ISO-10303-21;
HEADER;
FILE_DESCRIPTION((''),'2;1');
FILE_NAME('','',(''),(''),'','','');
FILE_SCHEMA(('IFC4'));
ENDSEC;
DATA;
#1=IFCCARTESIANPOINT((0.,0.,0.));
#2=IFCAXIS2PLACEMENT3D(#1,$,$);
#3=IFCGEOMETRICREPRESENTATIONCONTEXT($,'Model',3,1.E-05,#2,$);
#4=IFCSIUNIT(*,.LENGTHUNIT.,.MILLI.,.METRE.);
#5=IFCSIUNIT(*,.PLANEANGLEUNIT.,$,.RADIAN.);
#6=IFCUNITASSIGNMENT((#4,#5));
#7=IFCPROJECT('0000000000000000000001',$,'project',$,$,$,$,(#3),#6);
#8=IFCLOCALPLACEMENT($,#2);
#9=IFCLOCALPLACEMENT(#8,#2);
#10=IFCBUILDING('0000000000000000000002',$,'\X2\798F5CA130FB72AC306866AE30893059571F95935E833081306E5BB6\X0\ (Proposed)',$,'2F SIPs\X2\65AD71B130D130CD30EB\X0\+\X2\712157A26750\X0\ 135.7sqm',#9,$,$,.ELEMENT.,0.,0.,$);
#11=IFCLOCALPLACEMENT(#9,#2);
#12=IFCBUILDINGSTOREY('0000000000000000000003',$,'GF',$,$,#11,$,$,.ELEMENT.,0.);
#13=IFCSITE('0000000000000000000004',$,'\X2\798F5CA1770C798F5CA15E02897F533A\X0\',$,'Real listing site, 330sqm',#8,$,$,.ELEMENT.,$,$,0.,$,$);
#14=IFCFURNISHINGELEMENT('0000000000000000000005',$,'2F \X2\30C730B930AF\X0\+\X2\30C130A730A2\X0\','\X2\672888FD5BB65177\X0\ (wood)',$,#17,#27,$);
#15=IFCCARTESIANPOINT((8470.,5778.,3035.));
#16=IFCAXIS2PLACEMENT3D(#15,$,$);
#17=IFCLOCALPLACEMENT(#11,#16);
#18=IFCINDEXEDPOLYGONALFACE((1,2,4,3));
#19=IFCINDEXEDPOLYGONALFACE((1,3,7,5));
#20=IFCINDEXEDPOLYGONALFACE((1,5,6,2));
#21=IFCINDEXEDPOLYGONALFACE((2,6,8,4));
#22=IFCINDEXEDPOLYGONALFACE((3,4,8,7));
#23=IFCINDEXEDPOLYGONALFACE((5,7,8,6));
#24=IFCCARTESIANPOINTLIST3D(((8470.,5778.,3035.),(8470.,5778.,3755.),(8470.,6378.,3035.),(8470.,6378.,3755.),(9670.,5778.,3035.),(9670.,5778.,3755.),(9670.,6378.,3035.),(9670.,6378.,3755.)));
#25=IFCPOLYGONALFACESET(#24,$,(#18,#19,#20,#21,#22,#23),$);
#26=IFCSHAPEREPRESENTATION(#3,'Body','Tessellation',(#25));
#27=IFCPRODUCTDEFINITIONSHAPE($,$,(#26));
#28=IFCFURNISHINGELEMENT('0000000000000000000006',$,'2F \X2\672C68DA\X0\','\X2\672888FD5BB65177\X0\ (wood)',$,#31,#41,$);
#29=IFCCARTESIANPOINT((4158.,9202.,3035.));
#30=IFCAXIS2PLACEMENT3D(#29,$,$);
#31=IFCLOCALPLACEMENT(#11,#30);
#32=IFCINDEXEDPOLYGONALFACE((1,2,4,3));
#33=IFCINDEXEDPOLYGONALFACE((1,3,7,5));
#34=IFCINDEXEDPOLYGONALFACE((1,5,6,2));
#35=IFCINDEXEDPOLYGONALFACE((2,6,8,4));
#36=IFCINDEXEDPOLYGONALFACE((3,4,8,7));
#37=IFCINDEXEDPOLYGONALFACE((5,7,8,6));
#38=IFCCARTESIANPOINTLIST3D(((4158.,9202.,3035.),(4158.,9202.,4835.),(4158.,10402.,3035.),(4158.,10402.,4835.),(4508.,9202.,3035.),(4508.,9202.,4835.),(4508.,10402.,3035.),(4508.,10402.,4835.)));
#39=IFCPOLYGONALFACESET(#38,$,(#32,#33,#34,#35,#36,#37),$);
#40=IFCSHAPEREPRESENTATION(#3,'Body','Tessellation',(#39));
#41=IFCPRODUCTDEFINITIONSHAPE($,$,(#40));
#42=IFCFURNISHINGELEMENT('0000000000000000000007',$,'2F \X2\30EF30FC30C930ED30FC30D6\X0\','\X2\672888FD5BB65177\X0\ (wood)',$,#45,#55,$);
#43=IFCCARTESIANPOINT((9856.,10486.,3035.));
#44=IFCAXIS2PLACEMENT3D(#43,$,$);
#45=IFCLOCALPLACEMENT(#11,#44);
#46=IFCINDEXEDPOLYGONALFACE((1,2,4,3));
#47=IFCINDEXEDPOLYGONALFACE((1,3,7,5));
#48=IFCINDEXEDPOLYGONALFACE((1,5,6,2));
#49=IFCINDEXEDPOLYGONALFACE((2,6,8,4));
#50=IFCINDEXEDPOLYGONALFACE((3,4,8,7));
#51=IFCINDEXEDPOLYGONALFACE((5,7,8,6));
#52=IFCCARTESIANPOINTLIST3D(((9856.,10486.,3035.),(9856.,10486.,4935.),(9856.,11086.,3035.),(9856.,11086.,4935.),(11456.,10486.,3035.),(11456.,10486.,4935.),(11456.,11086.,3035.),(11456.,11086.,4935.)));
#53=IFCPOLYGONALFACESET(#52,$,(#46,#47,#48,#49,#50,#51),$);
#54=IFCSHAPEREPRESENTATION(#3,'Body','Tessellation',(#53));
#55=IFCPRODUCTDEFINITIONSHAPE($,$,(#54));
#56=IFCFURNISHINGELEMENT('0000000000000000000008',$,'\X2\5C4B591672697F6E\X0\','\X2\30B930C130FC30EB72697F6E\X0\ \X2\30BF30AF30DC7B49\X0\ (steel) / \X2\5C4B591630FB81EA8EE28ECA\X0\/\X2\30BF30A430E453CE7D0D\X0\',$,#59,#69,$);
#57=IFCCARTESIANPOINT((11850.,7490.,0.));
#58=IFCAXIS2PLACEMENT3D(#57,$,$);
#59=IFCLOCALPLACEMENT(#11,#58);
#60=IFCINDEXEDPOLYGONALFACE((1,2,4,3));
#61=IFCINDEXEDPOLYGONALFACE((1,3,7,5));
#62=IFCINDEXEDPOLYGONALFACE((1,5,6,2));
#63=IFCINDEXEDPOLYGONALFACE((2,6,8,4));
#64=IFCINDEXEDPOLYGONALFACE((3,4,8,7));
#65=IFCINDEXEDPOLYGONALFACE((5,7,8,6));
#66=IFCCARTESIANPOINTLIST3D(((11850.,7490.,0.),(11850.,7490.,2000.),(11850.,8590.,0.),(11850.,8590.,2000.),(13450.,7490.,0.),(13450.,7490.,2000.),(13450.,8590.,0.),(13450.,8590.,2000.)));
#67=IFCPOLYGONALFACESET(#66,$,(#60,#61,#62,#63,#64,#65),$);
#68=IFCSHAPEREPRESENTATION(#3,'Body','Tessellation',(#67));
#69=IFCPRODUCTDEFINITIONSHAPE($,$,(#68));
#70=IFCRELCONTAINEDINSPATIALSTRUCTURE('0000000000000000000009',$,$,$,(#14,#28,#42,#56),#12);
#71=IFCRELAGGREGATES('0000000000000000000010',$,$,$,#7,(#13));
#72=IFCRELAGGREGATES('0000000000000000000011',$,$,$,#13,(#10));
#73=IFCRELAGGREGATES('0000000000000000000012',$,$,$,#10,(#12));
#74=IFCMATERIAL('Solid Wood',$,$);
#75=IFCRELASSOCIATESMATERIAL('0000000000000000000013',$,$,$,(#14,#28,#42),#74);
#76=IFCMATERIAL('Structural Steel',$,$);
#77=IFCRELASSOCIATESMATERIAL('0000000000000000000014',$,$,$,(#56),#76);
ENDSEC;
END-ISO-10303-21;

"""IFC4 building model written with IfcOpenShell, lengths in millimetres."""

from ifc_helpers import new_model, si_unit, frame, frame_2d, origin, place, context, project, spatial, rectangle, extrude, material, element, save


model = new_model("IFC4")

# Units and contexts
model_context = context("Model", 3, precision=1e-05, world=origin())
ifc_project = project(units=[si_unit("LENGTHUNIT", "METRE", prefix="MILLI"), si_unit("PLANEANGLEUNIT", "RADIAN")], contexts=[model_context])

# Site, building, storey
site_placement = place(None, origin())
site = spatial("IfcSite", under=ifc_project, at=site_placement, Name="福岡県福岡市西区", ObjectType="Real listing site, 330sqm", CompositionType="ELEMENT", RefElevation=0.0)
building_placement = place(site_placement, origin())
building = spatial("IfcBuilding", under=site, at=building_placement, Name="福岡・犬と暮らす土間広めの家 (Proposed)", ObjectType="2F SIPs断熱パネル+無垢材 135.7sqm", CompositionType="ELEMENT", ElevationOfRefHeight=0.0, ElevationOfTerrain=0.0)
storey_placement = place(building_placement, origin())
storey = spatial("IfcBuildingStorey", under=building, at=storey_placement, Name="GF", CompositionType="ELEMENT", Elevation=0.0)

# Shared definitions
ifc_material_1 = material(Name="Solid Wood")

# Shared definitions
ifc_material_2 = material(Name="Structural Steel")

# Furnishing elements
furnishing_1_placement = place(storey_placement, frame((8470.0, 5778.0, 3035.0)))
element("IfcFurnishingElement", 1, at=furnishing_1_placement, inside=storey, material=ifc_material_1, Name="2F デスク+チェア", Description="木製家具 (wood)", context=model_context, shape_type="SweptSolid", body=[
    extrude(rectangle(XDim=1200.0, YDim=600.0, at=frame_2d((600.0, 300.0))), frame((8470.0, 5778.0, 3035.0)), (0.0, 0.0, 1.0), 720.0),
])
furnishing_2_placement = place(storey_placement, frame((4158.0, 9202.0, 3035.0)))
element("IfcFurnishingElement", 2, at=furnishing_2_placement, inside=storey, material=ifc_material_1, Name="2F 本棚", Description="木製家具 (wood)", context=model_context, shape_type="SweptSolid", body=[
    extrude(rectangle(XDim=350.0, YDim=1200.0, at=frame_2d((175.0, 600.0))), frame((4158.0, 9202.0, 3035.0)), (0.0, 0.0, 1.0), 1800.0),
])
furnishing_3_placement = place(storey_placement, frame((9856.0, 10486.0, 3035.0)))
element("IfcFurnishingElement", 3, at=furnishing_3_placement, inside=storey, material=ifc_material_1, Name="2F ワードローブ", Description="木製家具 (wood)", context=model_context, shape_type="SweptSolid", body=[
    extrude(rectangle(XDim=1600.0, YDim=600.0, at=frame_2d((800.0, 300.0))), frame((9856.0, 10486.0, 3035.0)), (0.0, 0.0, 1.0), 1900.0),
])
furnishing_4_placement = place(storey_placement, frame((11850.0, 7490.0, 0.0)))
element("IfcFurnishingElement", 4, at=furnishing_4_placement, inside=storey, material=ifc_material_2, Name="屋外物置", Description="スチール物置 タクボ等 (steel) / 屋外・自転車/タイヤ収納", context=model_context, shape_type="SweptSolid", body=[
    extrude(rectangle(XDim=1600.0, YDim=1100.0, at=frame_2d((800.0, 550.0))), frame((11850.0, 7490.0, 0.0)), (0.0, 0.0, 1.0), 2000.0),
])

save(model, "model.ifc")
